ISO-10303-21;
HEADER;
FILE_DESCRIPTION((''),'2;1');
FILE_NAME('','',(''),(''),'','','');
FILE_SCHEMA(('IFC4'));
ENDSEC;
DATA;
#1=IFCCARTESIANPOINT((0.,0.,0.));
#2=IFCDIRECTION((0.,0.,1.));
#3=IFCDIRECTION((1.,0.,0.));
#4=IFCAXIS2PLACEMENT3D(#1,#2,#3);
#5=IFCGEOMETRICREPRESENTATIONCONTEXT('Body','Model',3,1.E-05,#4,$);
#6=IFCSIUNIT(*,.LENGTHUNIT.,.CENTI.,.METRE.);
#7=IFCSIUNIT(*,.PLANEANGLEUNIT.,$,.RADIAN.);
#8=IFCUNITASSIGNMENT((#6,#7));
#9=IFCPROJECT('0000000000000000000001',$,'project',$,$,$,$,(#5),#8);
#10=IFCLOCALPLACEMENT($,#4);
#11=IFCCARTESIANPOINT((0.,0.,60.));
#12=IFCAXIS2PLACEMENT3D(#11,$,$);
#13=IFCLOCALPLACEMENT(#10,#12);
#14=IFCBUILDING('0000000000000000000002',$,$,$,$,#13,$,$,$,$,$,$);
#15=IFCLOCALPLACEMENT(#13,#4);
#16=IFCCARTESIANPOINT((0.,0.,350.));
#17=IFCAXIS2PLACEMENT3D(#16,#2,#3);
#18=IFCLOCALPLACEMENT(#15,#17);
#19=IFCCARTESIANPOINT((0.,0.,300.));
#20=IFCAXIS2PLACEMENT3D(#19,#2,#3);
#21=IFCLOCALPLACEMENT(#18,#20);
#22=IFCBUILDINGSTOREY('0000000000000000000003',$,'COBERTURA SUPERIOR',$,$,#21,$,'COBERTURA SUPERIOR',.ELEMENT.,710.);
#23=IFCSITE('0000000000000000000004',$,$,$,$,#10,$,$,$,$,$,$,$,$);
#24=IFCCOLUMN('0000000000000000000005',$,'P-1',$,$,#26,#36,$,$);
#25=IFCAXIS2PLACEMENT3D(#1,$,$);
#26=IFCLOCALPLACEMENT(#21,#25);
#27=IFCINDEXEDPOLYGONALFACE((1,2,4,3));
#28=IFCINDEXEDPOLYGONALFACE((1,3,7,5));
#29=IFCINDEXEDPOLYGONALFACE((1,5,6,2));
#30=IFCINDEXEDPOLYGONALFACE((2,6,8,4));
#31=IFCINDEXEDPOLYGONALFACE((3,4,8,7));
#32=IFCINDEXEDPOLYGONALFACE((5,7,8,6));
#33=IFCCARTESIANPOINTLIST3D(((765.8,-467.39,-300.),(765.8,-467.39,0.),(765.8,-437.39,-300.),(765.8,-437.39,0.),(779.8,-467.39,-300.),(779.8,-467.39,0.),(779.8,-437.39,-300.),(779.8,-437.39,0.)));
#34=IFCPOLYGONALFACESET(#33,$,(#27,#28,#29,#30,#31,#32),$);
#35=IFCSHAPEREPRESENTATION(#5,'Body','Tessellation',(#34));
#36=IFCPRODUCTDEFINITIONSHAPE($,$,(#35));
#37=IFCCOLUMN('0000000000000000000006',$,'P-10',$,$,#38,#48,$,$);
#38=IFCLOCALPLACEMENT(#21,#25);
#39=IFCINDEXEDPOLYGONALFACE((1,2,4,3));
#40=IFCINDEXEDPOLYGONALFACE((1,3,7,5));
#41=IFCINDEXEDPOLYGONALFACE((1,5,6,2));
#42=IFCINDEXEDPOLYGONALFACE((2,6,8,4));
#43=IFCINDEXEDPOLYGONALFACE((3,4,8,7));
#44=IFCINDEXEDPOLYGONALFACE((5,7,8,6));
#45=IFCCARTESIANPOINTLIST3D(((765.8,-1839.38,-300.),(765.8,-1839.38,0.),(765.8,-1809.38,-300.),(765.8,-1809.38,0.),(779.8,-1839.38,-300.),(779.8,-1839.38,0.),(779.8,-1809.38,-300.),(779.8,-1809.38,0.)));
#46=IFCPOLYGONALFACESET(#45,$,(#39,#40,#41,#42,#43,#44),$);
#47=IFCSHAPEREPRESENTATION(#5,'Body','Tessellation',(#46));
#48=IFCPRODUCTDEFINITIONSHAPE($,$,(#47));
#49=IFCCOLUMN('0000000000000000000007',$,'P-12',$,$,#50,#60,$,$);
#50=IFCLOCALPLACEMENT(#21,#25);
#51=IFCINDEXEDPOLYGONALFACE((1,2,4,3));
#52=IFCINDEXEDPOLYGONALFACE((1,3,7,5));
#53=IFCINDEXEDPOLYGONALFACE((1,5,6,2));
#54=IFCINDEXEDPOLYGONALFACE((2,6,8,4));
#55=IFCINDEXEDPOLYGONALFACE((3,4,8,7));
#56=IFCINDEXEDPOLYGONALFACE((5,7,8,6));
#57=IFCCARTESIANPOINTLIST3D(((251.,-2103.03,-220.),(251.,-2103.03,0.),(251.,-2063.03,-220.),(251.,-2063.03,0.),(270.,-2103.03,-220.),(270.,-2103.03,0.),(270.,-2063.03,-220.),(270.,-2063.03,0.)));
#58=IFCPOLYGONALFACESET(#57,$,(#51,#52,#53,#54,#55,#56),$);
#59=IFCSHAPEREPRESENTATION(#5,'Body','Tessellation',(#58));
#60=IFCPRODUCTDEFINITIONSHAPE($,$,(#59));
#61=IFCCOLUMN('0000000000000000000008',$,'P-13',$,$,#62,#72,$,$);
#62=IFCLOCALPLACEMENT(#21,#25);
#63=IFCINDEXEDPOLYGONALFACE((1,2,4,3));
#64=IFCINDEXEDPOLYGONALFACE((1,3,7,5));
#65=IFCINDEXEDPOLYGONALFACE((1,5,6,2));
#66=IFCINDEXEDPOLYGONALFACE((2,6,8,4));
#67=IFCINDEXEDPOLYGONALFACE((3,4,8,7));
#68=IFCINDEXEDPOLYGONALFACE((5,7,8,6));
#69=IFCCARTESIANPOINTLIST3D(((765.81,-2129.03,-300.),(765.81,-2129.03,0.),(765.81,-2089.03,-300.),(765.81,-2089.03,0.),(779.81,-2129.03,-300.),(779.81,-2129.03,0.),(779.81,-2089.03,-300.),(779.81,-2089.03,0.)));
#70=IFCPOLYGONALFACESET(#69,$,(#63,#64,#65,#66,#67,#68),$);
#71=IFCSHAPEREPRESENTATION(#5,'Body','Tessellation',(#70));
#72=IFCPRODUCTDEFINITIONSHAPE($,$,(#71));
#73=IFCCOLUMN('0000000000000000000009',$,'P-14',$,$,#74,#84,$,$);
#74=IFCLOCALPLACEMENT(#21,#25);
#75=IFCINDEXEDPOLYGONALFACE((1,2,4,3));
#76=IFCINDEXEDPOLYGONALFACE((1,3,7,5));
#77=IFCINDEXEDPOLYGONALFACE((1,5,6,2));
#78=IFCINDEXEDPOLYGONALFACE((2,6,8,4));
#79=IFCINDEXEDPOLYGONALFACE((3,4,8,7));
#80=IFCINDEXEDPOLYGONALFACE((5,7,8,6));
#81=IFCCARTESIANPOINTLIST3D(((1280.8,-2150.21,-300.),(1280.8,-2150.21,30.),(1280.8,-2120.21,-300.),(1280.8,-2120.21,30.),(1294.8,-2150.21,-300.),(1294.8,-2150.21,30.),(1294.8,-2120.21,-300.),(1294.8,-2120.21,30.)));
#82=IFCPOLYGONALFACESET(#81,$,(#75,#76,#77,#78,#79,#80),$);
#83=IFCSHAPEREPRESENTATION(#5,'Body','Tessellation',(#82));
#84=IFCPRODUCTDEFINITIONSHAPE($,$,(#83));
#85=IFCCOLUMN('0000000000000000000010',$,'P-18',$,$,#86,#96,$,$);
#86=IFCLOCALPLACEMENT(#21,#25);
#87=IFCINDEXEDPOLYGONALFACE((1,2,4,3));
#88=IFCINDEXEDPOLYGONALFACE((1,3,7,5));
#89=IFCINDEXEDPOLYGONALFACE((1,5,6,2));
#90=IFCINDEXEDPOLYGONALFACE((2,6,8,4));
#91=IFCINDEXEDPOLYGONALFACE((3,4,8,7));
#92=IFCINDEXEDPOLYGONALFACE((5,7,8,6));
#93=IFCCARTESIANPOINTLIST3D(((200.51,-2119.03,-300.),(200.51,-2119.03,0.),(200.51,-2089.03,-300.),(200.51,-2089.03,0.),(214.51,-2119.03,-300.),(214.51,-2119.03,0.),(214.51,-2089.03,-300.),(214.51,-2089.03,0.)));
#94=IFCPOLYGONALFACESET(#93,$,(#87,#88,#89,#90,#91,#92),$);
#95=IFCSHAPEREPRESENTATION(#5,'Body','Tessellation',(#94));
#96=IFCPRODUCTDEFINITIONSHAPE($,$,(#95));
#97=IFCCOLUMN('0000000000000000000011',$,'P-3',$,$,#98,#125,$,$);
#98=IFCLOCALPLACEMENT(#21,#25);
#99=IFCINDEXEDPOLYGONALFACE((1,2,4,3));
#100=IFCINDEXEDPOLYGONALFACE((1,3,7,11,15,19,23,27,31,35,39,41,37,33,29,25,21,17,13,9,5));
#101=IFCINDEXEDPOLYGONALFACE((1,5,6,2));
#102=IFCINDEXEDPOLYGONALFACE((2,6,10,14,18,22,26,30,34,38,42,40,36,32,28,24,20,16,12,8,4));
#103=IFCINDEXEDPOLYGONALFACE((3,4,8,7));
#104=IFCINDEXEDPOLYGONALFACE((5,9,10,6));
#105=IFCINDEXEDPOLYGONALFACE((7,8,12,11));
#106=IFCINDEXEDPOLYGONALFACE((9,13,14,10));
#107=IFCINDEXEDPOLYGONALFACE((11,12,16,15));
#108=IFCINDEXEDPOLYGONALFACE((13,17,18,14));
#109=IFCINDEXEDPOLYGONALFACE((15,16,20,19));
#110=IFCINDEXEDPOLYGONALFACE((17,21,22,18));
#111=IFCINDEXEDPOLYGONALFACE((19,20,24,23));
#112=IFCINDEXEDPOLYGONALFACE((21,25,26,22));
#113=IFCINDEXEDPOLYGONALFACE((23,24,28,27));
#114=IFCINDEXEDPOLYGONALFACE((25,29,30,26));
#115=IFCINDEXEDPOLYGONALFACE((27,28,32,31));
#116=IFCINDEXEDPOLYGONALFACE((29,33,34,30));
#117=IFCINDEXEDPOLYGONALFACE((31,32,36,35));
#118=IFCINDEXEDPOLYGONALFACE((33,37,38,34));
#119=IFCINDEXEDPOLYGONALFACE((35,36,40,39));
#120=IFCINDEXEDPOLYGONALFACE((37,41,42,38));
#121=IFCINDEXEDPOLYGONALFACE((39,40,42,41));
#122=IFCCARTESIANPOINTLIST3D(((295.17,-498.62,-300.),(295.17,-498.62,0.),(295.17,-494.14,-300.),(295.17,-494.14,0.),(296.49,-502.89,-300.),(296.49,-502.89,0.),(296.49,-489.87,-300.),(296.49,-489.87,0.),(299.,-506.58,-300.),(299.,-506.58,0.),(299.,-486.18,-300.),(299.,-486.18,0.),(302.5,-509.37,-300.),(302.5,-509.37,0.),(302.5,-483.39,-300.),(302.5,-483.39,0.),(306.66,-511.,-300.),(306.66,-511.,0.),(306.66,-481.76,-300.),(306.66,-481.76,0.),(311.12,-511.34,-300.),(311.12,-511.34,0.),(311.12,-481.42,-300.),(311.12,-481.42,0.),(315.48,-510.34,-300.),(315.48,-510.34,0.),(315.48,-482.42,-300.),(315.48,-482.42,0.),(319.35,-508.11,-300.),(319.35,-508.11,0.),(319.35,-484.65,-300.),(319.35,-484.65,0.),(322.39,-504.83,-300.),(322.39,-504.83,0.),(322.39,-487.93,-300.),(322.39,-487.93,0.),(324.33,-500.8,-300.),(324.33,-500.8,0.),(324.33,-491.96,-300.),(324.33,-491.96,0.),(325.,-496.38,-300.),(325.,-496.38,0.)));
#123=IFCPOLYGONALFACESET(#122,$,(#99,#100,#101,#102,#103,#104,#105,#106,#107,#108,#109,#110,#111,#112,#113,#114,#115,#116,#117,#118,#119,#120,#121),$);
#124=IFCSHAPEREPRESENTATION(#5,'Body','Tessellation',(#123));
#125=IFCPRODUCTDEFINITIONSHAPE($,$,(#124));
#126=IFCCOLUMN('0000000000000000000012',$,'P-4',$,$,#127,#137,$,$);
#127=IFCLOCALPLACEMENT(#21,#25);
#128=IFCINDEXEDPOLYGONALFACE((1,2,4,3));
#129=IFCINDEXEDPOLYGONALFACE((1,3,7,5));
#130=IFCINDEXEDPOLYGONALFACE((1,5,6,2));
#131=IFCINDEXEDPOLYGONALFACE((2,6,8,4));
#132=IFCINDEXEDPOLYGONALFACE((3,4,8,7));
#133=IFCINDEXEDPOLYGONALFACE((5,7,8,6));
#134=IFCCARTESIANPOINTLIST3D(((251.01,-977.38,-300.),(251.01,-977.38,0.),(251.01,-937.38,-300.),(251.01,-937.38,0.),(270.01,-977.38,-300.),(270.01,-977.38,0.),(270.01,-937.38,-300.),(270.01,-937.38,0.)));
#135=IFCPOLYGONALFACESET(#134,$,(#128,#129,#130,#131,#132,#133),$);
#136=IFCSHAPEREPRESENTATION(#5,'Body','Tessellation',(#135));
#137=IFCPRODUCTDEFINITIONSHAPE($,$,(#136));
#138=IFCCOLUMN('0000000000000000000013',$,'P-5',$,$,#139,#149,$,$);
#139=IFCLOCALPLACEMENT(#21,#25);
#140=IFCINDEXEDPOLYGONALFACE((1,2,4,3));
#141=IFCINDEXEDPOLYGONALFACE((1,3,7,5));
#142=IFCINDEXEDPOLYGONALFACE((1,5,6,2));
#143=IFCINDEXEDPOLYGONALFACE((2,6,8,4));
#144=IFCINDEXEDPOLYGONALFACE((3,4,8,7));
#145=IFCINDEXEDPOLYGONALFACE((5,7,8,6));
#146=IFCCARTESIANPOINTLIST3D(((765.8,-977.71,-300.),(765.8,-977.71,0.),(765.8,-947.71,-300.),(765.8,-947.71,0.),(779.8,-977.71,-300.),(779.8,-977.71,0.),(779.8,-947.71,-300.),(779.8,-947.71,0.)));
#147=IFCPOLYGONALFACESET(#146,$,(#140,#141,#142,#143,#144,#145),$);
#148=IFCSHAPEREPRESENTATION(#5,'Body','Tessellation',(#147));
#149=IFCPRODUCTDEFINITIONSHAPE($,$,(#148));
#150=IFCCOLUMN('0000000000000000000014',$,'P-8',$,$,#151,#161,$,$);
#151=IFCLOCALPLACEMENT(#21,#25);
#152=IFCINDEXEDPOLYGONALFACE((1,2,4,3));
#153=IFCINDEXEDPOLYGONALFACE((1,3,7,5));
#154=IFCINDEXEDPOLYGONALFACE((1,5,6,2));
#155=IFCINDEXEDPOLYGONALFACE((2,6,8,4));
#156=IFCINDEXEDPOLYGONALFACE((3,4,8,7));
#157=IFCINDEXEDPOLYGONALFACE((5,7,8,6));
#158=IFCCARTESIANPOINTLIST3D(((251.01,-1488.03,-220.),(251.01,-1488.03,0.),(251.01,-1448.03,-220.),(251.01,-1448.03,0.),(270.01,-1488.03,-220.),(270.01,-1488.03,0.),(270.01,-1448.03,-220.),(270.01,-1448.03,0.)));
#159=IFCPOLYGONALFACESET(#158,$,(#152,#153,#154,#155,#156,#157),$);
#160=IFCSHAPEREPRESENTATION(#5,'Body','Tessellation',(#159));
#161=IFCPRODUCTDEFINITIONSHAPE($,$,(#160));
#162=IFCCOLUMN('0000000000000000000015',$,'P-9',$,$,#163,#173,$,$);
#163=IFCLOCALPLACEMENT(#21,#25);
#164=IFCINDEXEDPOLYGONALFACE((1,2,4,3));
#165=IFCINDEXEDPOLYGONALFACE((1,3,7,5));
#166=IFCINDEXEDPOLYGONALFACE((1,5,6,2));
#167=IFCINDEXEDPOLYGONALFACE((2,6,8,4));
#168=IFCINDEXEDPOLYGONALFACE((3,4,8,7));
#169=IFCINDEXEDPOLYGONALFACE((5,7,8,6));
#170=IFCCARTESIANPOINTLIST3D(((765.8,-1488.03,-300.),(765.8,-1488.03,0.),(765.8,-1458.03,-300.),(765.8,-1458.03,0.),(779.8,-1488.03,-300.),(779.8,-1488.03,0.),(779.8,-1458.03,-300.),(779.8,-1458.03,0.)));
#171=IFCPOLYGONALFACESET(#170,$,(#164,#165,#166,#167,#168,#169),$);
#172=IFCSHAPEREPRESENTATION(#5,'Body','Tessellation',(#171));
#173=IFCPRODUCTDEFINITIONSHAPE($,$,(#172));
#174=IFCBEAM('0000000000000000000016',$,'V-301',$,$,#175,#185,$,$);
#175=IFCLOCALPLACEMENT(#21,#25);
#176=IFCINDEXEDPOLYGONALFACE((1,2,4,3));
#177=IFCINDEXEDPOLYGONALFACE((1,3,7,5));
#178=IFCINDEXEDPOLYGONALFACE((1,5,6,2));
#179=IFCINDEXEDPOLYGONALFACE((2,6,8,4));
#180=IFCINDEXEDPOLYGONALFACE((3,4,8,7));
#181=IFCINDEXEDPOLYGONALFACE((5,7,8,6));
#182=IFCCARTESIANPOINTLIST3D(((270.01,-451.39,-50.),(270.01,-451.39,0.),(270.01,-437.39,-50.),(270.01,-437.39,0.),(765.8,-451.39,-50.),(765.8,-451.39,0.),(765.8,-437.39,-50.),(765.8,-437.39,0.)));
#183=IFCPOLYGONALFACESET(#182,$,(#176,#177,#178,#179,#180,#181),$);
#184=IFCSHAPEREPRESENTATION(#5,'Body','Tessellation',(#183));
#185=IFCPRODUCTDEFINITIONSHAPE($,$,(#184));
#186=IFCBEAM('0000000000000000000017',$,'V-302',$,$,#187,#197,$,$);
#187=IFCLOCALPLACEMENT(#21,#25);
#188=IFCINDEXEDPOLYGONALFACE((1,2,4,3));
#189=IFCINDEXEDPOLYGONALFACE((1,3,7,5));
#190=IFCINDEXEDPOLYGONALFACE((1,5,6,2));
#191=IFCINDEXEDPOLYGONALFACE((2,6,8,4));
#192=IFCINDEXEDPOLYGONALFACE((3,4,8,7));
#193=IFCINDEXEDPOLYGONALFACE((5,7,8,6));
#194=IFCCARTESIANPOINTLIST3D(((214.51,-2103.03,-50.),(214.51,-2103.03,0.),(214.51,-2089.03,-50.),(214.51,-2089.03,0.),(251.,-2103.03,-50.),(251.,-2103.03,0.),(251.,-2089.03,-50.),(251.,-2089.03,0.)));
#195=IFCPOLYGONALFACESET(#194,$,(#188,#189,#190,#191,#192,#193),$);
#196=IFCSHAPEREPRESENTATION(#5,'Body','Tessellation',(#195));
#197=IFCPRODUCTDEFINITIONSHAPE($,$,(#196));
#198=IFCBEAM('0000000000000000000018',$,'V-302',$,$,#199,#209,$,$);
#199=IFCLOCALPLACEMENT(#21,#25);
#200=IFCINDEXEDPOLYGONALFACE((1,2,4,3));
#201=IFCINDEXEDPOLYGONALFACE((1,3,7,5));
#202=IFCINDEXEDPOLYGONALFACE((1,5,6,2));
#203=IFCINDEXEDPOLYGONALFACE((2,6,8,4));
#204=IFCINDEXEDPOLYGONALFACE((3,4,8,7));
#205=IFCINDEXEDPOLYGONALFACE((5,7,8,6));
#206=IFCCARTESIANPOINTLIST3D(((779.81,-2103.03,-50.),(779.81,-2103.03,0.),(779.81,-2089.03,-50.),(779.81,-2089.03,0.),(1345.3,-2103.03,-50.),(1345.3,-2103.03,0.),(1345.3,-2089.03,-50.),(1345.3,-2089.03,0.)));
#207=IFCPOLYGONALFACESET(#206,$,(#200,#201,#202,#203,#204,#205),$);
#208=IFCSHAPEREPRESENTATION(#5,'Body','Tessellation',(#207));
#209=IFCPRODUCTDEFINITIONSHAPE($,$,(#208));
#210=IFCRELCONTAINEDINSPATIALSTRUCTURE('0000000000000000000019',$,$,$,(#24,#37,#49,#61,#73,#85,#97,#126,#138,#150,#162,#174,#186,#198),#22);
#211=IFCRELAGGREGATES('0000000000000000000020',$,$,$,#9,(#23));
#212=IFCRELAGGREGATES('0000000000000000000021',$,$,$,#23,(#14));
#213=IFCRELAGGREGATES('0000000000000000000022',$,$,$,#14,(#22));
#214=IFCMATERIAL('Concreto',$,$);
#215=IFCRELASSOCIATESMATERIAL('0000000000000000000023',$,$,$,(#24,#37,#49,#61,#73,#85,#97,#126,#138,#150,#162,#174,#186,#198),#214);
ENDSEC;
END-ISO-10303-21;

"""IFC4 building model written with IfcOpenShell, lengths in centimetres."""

from ifc_helpers import new_model, si_unit, frame, origin_with_axes, origin_2d_with_axis, place, context, project, spatial, rectangle, circle, extrude, material, element, save


model = new_model("IFC4")

# Units and contexts
model_context = context("Model", 3, precision=1e-05, world=origin_with_axes(), identifier="Body")
ifc_project = project(units=[si_unit("LENGTHUNIT", "METRE", prefix="CENTI"), si_unit("PLANEANGLEUNIT", "RADIAN")], contexts=[model_context])

# Site, building, storey
site_placement = place(None, origin_with_axes())
site = spatial("IfcSite", under=ifc_project, at=site_placement)
building_placement = place(site_placement, frame((0.0, 0.0, 60.0)))
building = spatial("IfcBuilding", under=site, at=building_placement)
placement_1 = place(building_placement, origin_with_axes())
placement_2 = place(placement_1, frame((0.0, 0.0, 350.0), z_axis=(0.0, 0.0, 1.0), x_axis=(1.0, 0.0, 0.0)))
storey_placement = place(placement_2, frame((0.0, 0.0, 300.0), z_axis=(0.0, 0.0, 1.0), x_axis=(1.0, 0.0, 0.0)))
storey = spatial("IfcBuildingStorey", under=building, at=storey_placement, Name="COBERTURA SUPERIOR", LongName="COBERTURA SUPERIOR", CompositionType="ELEMENT", Elevation=710.0)

# Columns
ifc_material = material(Name="Concreto")
for number, where, z_axis, x_axis, name in (
    (1, (772.8, -452.39, 0.0), (0.0, 0.0, 1.0), (1.0, 0.0, 0.0), "P-1"),
    (2, (772.8, -1824.38, 0.0), (0.0, 0.0, 1.0), (1.0, 0.0, 0.0), "P-10"),
):
    element("IfcColumn", number, at=place(storey_placement, frame(where, z_axis=z_axis, x_axis=x_axis)), inside=storey, material=ifc_material, Name=name, context=model_context, shape_type="SolidModel", body=[
        extrude(rectangle(XDim=14.0, YDim=30.0, at=origin_2d_with_axis()), origin_with_axes(), (0.0, 0.0, -1.0), 300.0),
    ])
column_1_placement = place(storey_placement, frame((260.5, -2083.03, 0.0), z_axis=(0.0, 0.0, 1.0), x_axis=(1.0, 0.0, 0.0)))
element("IfcColumn", 3, at=column_1_placement, inside=storey, material=ifc_material, Name="P-12", context=model_context, shape_type="SolidModel", body=[
    extrude(rectangle(XDim=19.0, YDim=40.0, at=origin_2d_with_axis()), origin_with_axes(), (0.0, 0.0, -1.0), 220.0),
])
column_2_placement = place(storey_placement, frame((772.81, -2109.03, 0.0), z_axis=(0.0, 0.0, 1.0), x_axis=(1.0, 0.0, 0.0)))
element("IfcColumn", 4, at=column_2_placement, inside=storey, material=ifc_material, Name="P-13", context=model_context, shape_type="SolidModel", body=[
    extrude(rectangle(XDim=14.0, YDim=40.0, at=origin_2d_with_axis()), origin_with_axes(), (0.0, 0.0, -1.0), 300.0),
])
column_3_placement = place(storey_placement, frame((1287.8, -2135.21, 30.0), z_axis=(0.0, 0.0, 1.0), x_axis=(1.0, 0.0, 0.0)))
element("IfcColumn", 5, at=column_3_placement, inside=storey, material=ifc_material, Name="P-14", context=model_context, shape_type="SolidModel", body=[
    extrude(rectangle(XDim=14.0, YDim=30.0, at=origin_2d_with_axis()), origin_with_axes(), (0.0, 0.0, -1.0), 330.0),
])
column_4_placement = place(storey_placement, frame((207.51, -2104.03, 0.0), z_axis=(0.0, 0.0, 1.0), x_axis=(1.0, 0.0, 0.0)))
element("IfcColumn", 6, at=column_4_placement, inside=storey, material=ifc_material, Name="P-18", context=model_context, shape_type="SolidModel", body=[
    extrude(rectangle(XDim=14.0, YDim=30.0, at=origin_2d_with_axis()), origin_with_axes(), (0.0, 0.0, -1.0), 300.0),
])
column_5_placement = place(storey_placement, frame((310.0, -496.38, 0.0), z_axis=(0.0, 0.0, 1.0), x_axis=(1.0, 0.0, 0.0)))
element("IfcColumn", 7, at=column_5_placement, inside=storey, material=ifc_material, Name="P-3", context=model_context, shape_type="SolidModel", body=[
    extrude(circle(Radius=15.0, at=origin_2d_with_axis()), origin_with_axes(), (0.0, 0.0, -1.0), 300.0),
])
column_6_placement = place(storey_placement, frame((260.51, -957.38, 0.0), z_axis=(0.0, 0.0, 1.0), x_axis=(1.0, 0.0, 0.0)))
element("IfcColumn", 8, at=column_6_placement, inside=storey, material=ifc_material, Name="P-4", context=model_context, shape_type="SolidModel", body=[
    extrude(rectangle(XDim=19.0, YDim=40.0, at=origin_2d_with_axis()), origin_with_axes(), (0.0, 0.0, -1.0), 300.0),
])
column_7_placement = place(storey_placement, frame((772.8, -962.71, 0.0), z_axis=(0.0, 0.0, 1.0), x_axis=(1.0, 0.0, 0.0)))
element("IfcColumn", 9, at=column_7_placement, inside=storey, material=ifc_material, Name="P-5", context=model_context, shape_type="SolidModel", body=[
    extrude(rectangle(XDim=14.0, YDim=30.0, at=origin_2d_with_axis()), origin_with_axes(), (0.0, 0.0, -1.0), 300.0),
])
column_8_placement = place(storey_placement, frame((260.51, -1468.03, 0.0), z_axis=(0.0, 0.0, 1.0), x_axis=(1.0, 0.0, 0.0)))
element("IfcColumn", 10, at=column_8_placement, inside=storey, material=ifc_material, Name="P-8", context=model_context, shape_type="SolidModel", body=[
    extrude(rectangle(XDim=19.0, YDim=40.0, at=origin_2d_with_axis()), origin_with_axes(), (0.0, 0.0, -1.0), 220.0),
])
column_9_placement = place(storey_placement, frame((772.8, -1473.03, 0.0), z_axis=(0.0, 0.0, 1.0), x_axis=(1.0, 0.0, 0.0)))
element("IfcColumn", 11, at=column_9_placement, inside=storey, material=ifc_material, Name="P-9", context=model_context, shape_type="SolidModel", body=[
    extrude(rectangle(XDim=14.0, YDim=30.0, at=origin_2d_with_axis()), origin_with_axes(), (0.0, 0.0, -1.0), 300.0),
])

# Beams
beam_1_placement = place(storey_placement, frame((517.9, -444.39, 0.0), z_axis=(0.0, 0.0, 1.0), x_axis=(1.0, 0.0, 0.0)))
element("IfcBeam", 12, at=beam_1_placement, inside=storey, material=ifc_material, Name="V-301", context=model_context, shape_type="SolidModel", body=[
    extrude(rectangle(XDim=14.0, YDim=50.0, at=origin_2d_with_axis()), frame((-247.9, 0.0, -25.0), z_axis=(1.0, 0.0, 0.0), x_axis=(0.0, -1.0, 0.0)), (0.0, 0.0, 1.0), 495.79),
])
beam_2_placement = place(storey_placement, frame((232.75, -2096.03, 0.0), z_axis=(0.0, 0.0, 1.0), x_axis=(1.0, 0.0, 0.0)))
element("IfcBeam", 13, at=beam_2_placement, inside=storey, material=ifc_material, Name="V-302", context=model_context, shape_type="SolidModel", body=[
    extrude(rectangle(XDim=14.0, YDim=50.0, at=origin_2d_with_axis()), frame((-18.25, 0.0, -25.0), z_axis=(1.0, 0.0, 0.0), x_axis=(0.0, -1.0, 0.0)), (0.0, 0.0, 1.0), 36.49),
])
beam_3_placement = place(storey_placement, frame((1062.56, -2096.03, 0.0), z_axis=(0.0, 0.0, 1.0), x_axis=(1.0, 0.0, 0.0)))
element("IfcBeam", 14, at=beam_3_placement, inside=storey, material=ifc_material, Name="V-302", context=model_context, shape_type="SolidModel", body=[
    extrude(rectangle(XDim=14.0, YDim=50.0, at=origin_2d_with_axis()), frame((-282.75, 0.0, -25.0), z_axis=(1.0, 0.0, 0.0), x_axis=(0.0, -1.0, 0.0)), (0.0, 0.0, 1.0), 565.49),
])

save(model, "model.ifc")
